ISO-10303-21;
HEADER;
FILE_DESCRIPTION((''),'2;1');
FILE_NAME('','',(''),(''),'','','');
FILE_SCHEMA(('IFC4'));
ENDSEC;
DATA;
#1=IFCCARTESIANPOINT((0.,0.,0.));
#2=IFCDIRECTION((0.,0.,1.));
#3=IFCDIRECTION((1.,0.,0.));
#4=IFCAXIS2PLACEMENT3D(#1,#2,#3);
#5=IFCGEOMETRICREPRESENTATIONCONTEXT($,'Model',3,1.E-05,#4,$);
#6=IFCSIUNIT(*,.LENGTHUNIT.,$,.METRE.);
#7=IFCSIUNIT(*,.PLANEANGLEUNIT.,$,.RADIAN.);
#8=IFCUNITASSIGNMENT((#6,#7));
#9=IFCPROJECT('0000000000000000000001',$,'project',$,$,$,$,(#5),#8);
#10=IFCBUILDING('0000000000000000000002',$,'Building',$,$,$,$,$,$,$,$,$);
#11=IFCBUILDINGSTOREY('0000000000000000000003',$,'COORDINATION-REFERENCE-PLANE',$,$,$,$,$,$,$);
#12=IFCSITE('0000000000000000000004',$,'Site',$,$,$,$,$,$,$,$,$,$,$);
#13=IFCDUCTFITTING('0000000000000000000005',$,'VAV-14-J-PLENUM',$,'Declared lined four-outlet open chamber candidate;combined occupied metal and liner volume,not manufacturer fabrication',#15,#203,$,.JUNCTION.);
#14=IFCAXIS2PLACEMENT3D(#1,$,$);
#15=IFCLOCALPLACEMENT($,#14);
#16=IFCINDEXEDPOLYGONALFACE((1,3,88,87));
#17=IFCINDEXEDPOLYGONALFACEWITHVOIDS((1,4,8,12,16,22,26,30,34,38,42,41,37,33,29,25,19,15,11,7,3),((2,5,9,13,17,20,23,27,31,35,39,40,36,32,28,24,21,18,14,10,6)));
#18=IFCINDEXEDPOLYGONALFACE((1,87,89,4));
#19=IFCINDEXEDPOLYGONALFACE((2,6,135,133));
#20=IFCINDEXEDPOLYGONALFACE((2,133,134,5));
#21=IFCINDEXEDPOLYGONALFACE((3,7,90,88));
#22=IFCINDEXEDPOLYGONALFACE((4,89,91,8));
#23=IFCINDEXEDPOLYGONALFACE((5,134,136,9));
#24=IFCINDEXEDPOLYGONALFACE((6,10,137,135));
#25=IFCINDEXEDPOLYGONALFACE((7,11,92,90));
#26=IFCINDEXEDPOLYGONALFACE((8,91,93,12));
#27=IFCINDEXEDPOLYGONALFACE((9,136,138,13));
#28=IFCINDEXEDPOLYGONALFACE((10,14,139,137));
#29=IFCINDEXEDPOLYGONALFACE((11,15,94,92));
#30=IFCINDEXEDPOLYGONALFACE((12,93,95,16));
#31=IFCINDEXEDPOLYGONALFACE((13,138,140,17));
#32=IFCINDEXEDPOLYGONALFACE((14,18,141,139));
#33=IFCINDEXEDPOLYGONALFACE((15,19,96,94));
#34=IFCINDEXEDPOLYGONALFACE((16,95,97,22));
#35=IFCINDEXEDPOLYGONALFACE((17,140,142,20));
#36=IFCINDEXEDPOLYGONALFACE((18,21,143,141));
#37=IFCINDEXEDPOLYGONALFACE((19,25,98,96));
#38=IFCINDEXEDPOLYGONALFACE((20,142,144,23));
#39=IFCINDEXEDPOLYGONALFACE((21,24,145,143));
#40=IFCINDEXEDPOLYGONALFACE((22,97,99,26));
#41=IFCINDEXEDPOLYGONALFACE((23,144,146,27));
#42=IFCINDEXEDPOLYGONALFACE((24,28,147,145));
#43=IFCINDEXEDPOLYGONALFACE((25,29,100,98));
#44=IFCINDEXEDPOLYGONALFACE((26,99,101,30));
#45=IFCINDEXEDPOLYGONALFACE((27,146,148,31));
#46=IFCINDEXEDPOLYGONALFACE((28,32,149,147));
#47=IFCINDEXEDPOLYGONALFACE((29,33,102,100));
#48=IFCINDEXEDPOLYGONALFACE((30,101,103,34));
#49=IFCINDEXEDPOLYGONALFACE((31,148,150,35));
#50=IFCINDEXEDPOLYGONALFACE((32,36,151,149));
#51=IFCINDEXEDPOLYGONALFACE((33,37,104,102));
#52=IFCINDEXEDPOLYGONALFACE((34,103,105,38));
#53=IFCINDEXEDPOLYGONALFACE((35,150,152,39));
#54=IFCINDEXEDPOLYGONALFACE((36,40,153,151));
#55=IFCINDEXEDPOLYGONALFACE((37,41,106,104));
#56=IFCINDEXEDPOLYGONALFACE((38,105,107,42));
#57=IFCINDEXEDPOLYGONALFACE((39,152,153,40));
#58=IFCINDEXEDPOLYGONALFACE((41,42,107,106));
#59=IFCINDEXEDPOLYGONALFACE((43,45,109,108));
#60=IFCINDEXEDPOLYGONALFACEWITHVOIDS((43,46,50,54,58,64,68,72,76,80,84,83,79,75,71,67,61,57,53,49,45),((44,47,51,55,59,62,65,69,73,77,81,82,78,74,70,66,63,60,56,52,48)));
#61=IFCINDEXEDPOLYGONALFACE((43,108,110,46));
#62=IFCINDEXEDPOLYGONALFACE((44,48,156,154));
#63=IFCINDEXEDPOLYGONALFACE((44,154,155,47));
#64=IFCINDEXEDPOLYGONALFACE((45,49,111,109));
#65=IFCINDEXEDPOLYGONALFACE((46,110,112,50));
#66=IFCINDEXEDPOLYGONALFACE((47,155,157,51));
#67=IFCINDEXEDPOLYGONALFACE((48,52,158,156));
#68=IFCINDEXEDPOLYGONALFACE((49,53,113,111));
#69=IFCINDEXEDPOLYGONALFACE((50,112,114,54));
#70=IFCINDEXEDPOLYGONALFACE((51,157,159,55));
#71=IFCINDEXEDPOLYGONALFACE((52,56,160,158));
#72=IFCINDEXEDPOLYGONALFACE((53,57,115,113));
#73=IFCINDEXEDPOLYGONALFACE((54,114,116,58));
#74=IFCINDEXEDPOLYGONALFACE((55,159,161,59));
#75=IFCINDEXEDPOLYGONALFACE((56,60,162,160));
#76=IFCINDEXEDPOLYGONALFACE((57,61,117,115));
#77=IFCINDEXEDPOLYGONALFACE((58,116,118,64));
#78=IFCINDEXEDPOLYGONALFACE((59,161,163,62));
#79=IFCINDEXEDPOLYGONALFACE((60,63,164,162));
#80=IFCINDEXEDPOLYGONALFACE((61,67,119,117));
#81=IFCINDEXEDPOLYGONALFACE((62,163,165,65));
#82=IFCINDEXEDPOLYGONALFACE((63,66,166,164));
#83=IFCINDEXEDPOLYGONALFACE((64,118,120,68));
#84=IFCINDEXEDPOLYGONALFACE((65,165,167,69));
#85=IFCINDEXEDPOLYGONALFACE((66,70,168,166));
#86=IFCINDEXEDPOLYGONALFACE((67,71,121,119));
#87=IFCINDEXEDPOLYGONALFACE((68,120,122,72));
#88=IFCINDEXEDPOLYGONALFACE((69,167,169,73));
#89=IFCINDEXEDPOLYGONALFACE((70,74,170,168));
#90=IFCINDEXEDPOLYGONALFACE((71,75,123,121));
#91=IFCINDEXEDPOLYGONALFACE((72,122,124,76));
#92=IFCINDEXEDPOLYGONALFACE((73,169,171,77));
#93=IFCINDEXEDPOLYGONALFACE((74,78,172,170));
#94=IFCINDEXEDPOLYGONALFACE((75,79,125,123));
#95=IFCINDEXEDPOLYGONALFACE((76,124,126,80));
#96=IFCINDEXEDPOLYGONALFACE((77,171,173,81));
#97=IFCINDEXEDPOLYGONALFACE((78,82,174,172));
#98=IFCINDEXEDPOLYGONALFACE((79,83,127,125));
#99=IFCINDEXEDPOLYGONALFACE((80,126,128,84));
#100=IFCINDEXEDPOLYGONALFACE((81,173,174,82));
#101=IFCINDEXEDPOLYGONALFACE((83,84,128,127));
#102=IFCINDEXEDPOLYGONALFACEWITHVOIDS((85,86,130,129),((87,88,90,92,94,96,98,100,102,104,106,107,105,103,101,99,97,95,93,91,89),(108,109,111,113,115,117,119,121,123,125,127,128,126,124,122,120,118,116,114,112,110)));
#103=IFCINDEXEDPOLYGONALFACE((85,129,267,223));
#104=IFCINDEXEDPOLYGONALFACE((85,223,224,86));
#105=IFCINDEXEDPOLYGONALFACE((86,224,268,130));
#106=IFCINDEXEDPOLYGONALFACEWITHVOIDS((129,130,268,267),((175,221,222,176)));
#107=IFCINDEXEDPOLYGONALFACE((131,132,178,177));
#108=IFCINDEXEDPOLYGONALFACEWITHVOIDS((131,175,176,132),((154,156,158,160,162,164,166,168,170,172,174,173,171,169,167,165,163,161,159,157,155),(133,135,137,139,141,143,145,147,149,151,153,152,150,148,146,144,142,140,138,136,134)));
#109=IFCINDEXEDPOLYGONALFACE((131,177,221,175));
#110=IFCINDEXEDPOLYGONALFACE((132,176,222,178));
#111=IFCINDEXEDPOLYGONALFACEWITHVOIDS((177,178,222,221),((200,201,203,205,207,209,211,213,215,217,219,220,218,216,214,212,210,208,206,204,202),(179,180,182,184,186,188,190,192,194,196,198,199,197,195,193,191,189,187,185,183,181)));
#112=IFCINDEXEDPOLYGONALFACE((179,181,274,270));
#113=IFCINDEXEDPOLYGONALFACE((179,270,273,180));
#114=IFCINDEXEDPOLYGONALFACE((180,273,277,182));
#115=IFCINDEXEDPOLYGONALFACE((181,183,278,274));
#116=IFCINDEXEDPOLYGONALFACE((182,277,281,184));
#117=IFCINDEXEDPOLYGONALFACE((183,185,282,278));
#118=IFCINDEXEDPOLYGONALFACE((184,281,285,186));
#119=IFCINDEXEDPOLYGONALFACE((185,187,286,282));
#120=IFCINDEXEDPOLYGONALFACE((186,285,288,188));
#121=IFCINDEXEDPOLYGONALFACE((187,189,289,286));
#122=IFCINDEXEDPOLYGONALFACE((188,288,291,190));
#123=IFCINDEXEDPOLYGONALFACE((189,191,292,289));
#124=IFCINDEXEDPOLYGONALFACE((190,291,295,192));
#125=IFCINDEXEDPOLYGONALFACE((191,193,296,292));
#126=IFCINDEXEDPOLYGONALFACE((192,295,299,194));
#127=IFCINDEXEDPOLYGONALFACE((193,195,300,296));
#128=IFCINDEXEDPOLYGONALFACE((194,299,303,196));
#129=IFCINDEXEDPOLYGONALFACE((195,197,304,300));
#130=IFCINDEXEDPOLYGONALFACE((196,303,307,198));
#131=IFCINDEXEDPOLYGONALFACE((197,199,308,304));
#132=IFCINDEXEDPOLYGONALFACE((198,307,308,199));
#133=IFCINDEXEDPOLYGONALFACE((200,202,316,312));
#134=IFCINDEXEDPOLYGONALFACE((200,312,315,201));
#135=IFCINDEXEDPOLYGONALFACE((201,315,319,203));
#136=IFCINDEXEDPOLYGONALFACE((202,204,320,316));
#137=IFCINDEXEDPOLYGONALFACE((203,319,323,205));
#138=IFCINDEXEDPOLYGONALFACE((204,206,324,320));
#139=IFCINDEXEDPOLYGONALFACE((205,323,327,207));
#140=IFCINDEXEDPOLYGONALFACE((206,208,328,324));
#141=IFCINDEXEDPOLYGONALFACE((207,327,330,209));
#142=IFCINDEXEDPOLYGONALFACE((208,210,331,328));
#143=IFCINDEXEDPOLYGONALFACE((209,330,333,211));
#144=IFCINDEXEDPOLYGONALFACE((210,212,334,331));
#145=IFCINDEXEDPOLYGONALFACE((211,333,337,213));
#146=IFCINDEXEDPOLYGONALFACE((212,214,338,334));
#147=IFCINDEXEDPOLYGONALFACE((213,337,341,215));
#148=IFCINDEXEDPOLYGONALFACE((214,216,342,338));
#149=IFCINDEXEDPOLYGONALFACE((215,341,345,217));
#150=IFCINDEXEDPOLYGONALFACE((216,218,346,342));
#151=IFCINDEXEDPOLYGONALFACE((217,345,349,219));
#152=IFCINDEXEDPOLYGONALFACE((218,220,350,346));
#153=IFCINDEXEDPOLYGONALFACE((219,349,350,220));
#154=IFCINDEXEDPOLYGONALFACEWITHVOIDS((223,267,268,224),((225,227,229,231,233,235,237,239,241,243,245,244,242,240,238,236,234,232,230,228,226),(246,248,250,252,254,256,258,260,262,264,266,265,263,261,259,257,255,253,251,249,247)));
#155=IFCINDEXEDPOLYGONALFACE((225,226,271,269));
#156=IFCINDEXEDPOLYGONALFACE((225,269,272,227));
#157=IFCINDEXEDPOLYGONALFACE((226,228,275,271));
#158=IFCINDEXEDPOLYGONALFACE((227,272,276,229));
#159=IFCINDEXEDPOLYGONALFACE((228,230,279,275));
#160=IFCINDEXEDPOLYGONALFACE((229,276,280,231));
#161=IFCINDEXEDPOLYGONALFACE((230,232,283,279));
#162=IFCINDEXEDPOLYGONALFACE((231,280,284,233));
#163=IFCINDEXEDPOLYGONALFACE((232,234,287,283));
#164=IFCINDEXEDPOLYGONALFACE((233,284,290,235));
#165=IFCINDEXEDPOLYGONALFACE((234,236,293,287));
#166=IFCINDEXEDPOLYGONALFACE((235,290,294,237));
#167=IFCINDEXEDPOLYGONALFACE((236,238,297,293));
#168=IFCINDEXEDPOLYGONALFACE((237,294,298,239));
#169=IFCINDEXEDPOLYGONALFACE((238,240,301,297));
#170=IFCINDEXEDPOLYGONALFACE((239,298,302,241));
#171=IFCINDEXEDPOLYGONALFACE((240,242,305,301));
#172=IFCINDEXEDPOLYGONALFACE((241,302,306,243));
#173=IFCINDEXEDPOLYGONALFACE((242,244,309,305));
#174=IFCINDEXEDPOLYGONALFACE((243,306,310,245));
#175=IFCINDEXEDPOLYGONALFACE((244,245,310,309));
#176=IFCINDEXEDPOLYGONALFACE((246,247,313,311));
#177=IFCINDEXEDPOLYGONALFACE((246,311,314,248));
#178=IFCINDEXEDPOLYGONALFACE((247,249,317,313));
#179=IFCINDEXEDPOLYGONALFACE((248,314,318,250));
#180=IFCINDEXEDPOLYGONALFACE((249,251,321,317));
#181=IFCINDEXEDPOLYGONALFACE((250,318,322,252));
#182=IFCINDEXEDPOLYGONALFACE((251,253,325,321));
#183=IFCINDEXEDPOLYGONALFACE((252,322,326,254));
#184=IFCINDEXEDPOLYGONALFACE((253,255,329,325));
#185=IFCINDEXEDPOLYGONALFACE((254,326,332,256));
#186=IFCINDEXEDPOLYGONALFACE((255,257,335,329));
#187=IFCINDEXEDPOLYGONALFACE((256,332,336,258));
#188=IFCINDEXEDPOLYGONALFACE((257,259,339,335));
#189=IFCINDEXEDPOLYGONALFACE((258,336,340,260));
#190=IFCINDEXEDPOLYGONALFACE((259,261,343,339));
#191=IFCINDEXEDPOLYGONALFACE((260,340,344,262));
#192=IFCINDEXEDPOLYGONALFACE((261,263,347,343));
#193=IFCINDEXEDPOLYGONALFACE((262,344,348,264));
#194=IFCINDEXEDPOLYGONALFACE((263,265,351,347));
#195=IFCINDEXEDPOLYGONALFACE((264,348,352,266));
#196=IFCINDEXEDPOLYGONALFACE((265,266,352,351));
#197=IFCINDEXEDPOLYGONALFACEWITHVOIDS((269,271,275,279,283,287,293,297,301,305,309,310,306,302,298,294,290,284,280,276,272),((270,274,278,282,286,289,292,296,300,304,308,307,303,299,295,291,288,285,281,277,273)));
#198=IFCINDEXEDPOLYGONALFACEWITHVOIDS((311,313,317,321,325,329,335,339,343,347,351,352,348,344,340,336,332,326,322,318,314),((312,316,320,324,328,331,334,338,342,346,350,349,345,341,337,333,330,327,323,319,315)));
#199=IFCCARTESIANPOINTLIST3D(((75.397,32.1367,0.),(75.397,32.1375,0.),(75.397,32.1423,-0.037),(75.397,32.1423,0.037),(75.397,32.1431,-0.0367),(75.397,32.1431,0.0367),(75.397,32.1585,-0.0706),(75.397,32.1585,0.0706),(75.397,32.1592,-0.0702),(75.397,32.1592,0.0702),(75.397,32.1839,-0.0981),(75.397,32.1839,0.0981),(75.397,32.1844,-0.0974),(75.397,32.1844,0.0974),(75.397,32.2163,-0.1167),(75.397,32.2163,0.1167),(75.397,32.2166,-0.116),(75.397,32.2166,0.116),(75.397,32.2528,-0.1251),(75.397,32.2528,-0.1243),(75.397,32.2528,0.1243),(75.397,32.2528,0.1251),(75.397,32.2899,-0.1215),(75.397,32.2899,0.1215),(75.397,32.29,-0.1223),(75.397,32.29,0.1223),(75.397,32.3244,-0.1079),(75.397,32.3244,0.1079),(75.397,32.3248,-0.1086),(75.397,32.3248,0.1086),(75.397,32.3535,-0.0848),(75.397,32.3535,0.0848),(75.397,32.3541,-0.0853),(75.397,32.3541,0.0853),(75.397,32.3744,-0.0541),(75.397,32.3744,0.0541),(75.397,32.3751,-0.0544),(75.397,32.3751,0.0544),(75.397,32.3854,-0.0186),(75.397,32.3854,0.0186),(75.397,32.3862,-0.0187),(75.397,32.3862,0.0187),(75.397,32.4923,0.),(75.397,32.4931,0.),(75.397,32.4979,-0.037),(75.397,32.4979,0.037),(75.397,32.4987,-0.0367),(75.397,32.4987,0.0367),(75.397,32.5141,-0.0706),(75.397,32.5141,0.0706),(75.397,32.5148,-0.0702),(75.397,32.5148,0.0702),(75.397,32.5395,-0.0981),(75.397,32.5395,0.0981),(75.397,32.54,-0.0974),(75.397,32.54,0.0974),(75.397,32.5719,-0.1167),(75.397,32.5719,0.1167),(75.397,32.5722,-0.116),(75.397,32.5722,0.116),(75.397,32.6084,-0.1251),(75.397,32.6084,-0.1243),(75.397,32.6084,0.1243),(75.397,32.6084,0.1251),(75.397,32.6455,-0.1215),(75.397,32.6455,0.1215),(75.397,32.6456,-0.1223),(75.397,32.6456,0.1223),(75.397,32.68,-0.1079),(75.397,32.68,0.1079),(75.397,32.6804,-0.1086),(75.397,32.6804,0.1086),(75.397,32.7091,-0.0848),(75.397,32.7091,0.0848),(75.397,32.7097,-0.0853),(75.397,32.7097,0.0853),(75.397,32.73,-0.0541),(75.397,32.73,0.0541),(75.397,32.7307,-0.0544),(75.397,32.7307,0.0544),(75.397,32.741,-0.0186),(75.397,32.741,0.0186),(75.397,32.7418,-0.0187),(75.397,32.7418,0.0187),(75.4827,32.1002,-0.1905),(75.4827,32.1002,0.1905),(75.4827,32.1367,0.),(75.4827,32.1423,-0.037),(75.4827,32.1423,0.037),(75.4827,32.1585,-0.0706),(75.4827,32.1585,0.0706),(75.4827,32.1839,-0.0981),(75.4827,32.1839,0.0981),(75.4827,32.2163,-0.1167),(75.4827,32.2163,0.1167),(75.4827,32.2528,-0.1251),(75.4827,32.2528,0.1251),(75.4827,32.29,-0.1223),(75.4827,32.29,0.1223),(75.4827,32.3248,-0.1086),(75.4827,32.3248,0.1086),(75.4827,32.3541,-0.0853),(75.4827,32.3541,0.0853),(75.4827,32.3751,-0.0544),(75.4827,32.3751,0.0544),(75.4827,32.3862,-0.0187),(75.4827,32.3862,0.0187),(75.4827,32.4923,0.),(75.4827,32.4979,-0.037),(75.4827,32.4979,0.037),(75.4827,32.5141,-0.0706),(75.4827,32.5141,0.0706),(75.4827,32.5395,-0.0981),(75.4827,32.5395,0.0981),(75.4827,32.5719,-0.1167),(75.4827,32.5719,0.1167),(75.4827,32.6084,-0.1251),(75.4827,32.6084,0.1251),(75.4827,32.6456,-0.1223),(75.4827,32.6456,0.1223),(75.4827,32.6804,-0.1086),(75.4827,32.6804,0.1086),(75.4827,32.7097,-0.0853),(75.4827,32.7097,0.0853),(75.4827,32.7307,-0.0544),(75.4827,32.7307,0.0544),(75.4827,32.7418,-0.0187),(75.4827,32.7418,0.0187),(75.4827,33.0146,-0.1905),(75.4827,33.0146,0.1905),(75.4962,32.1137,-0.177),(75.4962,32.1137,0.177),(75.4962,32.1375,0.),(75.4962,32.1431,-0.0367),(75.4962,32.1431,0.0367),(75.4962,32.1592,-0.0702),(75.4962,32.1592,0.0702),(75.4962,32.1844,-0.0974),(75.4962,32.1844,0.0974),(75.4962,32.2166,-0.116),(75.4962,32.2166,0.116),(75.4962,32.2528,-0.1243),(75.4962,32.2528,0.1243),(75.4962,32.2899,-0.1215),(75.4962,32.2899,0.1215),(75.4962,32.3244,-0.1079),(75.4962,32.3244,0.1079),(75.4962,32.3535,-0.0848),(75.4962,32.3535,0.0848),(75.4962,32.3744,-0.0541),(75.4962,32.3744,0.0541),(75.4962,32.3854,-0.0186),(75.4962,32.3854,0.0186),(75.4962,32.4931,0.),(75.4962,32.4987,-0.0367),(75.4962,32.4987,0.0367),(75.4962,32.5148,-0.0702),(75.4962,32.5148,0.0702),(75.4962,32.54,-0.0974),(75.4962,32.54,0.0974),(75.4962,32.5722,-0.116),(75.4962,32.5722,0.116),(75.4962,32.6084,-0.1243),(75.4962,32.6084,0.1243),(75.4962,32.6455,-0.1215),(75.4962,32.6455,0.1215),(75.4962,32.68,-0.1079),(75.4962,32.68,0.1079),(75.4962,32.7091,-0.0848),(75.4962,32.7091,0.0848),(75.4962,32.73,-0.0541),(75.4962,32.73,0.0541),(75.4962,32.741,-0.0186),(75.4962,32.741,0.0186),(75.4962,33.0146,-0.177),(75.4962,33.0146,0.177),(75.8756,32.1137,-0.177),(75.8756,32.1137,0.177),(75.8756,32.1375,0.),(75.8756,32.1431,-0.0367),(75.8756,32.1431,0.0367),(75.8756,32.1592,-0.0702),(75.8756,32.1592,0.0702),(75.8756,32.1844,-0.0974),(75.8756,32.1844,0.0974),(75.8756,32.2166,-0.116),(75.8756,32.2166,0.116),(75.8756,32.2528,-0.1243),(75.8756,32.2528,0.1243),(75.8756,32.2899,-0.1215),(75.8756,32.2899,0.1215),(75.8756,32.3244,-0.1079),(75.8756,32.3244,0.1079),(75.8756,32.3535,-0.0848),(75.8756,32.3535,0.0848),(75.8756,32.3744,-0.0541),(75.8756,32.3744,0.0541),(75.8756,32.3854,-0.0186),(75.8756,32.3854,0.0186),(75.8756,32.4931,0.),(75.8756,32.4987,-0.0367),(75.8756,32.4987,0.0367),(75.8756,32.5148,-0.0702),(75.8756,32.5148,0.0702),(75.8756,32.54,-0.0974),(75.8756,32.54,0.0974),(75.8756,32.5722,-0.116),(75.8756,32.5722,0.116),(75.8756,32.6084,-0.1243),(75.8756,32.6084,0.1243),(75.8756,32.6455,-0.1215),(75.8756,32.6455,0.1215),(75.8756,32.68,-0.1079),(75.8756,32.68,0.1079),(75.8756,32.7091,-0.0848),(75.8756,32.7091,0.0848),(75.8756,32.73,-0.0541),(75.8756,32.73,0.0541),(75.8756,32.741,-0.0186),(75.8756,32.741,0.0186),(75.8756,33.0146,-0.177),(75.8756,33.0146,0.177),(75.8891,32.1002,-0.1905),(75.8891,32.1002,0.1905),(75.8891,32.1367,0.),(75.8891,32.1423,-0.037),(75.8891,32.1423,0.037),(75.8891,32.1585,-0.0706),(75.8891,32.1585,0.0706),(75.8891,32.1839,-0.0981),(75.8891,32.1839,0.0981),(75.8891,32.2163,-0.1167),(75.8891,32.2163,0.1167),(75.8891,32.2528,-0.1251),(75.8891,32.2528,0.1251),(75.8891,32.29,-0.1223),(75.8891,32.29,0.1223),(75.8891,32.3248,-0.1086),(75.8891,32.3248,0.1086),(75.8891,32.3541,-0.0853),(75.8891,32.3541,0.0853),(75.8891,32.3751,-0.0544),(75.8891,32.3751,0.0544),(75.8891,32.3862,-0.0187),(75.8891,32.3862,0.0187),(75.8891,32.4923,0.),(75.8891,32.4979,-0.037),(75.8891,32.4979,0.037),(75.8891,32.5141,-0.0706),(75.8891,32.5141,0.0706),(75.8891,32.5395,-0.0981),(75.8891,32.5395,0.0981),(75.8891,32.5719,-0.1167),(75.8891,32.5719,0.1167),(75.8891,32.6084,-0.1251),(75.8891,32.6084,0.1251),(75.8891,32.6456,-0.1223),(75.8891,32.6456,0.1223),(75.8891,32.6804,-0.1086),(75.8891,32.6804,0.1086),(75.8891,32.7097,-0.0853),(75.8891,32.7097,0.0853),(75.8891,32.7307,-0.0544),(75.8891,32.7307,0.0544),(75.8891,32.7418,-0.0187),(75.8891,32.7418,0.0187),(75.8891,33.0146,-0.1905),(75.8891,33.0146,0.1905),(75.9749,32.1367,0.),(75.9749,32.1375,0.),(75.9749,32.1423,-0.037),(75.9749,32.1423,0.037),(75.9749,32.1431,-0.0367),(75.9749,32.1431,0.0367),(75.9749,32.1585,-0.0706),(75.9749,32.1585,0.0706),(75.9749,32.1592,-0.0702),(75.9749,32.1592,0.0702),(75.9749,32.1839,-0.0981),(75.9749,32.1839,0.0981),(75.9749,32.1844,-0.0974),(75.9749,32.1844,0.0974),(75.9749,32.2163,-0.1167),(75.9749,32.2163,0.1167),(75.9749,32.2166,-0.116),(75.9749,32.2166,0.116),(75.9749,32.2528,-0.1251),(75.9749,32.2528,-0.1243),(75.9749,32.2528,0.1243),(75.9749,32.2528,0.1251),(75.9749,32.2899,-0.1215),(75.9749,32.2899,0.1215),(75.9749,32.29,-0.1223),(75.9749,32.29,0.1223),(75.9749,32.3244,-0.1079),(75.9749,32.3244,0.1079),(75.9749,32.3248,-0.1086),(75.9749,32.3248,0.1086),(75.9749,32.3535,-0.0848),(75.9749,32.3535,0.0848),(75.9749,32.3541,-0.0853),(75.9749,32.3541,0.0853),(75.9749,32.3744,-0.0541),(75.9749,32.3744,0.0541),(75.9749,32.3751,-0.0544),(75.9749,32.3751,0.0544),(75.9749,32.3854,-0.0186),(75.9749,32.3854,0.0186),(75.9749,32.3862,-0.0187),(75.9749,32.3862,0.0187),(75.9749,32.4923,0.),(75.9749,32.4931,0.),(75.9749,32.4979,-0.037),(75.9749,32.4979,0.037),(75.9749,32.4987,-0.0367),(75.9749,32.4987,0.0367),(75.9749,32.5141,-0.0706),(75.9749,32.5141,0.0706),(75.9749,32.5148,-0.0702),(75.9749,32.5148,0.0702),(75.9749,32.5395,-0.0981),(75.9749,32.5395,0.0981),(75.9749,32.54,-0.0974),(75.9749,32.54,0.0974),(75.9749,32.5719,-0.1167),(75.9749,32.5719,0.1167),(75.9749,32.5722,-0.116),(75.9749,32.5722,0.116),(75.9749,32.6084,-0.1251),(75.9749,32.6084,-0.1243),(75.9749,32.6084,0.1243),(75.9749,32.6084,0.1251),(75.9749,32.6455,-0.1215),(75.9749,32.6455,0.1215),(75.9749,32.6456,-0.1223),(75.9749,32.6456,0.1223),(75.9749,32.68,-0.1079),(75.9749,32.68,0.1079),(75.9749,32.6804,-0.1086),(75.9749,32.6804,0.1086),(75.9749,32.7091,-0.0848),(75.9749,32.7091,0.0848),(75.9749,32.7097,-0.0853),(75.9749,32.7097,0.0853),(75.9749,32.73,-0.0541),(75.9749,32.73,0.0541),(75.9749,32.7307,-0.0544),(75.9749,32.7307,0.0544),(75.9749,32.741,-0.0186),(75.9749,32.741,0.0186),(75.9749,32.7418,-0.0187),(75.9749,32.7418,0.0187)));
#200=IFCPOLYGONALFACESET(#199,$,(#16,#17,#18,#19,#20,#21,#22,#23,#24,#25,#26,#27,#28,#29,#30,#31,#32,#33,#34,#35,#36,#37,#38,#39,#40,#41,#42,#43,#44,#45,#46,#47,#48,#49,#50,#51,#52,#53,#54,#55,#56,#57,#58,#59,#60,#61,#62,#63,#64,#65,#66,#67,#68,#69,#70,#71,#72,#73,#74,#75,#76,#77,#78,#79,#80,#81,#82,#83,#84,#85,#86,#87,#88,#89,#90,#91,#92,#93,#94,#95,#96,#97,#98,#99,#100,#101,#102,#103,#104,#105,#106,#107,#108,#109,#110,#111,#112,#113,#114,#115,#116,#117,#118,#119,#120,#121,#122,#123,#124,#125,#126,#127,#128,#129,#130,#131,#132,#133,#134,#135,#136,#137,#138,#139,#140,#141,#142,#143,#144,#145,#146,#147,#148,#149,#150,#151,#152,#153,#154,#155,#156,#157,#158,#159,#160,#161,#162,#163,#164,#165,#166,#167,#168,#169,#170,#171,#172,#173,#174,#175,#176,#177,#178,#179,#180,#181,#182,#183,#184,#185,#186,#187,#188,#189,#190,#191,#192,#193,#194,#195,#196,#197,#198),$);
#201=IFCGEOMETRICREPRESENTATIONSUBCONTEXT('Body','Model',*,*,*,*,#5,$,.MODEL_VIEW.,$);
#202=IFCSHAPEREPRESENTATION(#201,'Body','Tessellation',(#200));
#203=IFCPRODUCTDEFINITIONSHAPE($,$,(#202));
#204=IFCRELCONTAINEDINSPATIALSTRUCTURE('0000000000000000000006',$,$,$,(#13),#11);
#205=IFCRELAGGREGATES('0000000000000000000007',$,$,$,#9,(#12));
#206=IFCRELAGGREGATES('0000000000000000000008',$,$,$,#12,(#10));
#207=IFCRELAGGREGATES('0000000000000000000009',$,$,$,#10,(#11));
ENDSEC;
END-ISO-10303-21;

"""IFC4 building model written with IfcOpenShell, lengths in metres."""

from ifc_helpers import new_model, si_unit, frame, origin_with_axes, place, context, subcontext, project, spatial, rectangle, circle, extrude, boolean, element, save


model = new_model("IFC4")

# Units and contexts
model_context = context("Model", 3, precision=1e-05, world=origin_with_axes())
body_context_1 = subcontext(model_context, "Body", "Model", "MODEL_VIEW")
ifc_project = project(units=[si_unit("LENGTHUNIT", "METRE"), si_unit("PLANEANGLEUNIT", "RADIAN")], contexts=[model_context])

# Site, building, storey
site = spatial("IfcSite", under=ifc_project, Name="Site")
building = spatial("IfcBuilding", under=site, Name="Building")
storey = spatial("IfcBuildingStorey", under=building, Name="COORDINATION-REFERENCE-PLANE")

# Duct fitting
duct_fitting_1_placement = place(None, frame((75.4827, 32.1002, -0.1905), z_axis=(0.0, 0.0, 1.0), x_axis=(1.0, 0.0, 0.0)))
solid_1 = boolean("UNION", boolean("UNION", boolean("UNION", boolean("UNION", extrude(rectangle(XDim=0.3794, YDim=0.354), frame((0.2032, 0.9244, 0.1905), z_axis=(0.0, -1.0, 0.0), x_axis=(1.0, 0.0, 0.0)), (0.0, 0.0, 1.0), 0.9109), extrude(circle(Radius=0.1246), frame((0.0235, 0.5175, 0.1905), z_axis=(-1.0, 0.0, 0.0), x_axis=(0.0, -1.0, 0.0)), (0.0, 0.0, 1.0), 0.1192)), extrude(circle(Radius=0.1246), frame((0.3829, 0.5175, 0.1905), z_axis=(1.0, 0.0, 0.0), x_axis=(0.0, -1.0, 0.0)), (0.0, 0.0, 1.0), 0.1192)), extrude(circle(Radius=0.1246), frame((0.0235, 0.1619, 0.1905), z_axis=(-1.0, 0.0, 0.0), x_axis=(0.0, -1.0, 0.0)), (0.0, 0.0, 1.0), 0.1192)), extrude(circle(Radius=0.1246), frame((0.3829, 0.1619, 0.1905), z_axis=(1.0, 0.0, 0.0), x_axis=(0.0, -1.0, 0.0)), (0.0, 0.0, 1.0), 0.1192))
element("IfcDuctFitting", 1, at=duct_fitting_1_placement, inside=storey, Name="VAV-14-J-PLENUM", ObjectType="Declared lined four-outlet open chamber candidate;combined occupied metal and liner volume,not manufacturer fabrication", PredefinedType="JUNCTION", context=body_context_1, shape_type="CSG", body=[
    boolean("DIFFERENCE", boolean("UNION", boolean("UNION", boolean("UNION", boolean("UNION", extrude(rectangle(XDim=0.4064, YDim=0.381), frame((0.2032, 0.9144, 0.1905), z_axis=(0.0, -1.0, 0.0), x_axis=(1.0, 0.0, 0.0)), (0.0, 0.0, 1.0), 0.9144), extrude(circle(Radius=0.1254), frame((0.0235, 0.5175, 0.1905), z_axis=(-1.0, 0.0, 0.0), x_axis=(0.0, -1.0, 0.0)), (0.0, 0.0, 1.0), 0.1092)), extrude(circle(Radius=0.1254), frame((0.3829, 0.5175, 0.1905), z_axis=(1.0, 0.0, 0.0), x_axis=(0.0, -1.0, 0.0)), (0.0, 0.0, 1.0), 0.1092)), extrude(circle(Radius=0.1254), frame((0.0235, 0.1619, 0.1905), z_axis=(-1.0, 0.0, 0.0), x_axis=(0.0, -1.0, 0.0)), (0.0, 0.0, 1.0), 0.1092)), extrude(circle(Radius=0.1254), frame((0.3829, 0.1619, 0.1905), z_axis=(1.0, 0.0, 0.0), x_axis=(0.0, -1.0, 0.0)), (0.0, 0.0, 1.0), 0.1092)), solid_1),
])

save(model, "model.ifc")
